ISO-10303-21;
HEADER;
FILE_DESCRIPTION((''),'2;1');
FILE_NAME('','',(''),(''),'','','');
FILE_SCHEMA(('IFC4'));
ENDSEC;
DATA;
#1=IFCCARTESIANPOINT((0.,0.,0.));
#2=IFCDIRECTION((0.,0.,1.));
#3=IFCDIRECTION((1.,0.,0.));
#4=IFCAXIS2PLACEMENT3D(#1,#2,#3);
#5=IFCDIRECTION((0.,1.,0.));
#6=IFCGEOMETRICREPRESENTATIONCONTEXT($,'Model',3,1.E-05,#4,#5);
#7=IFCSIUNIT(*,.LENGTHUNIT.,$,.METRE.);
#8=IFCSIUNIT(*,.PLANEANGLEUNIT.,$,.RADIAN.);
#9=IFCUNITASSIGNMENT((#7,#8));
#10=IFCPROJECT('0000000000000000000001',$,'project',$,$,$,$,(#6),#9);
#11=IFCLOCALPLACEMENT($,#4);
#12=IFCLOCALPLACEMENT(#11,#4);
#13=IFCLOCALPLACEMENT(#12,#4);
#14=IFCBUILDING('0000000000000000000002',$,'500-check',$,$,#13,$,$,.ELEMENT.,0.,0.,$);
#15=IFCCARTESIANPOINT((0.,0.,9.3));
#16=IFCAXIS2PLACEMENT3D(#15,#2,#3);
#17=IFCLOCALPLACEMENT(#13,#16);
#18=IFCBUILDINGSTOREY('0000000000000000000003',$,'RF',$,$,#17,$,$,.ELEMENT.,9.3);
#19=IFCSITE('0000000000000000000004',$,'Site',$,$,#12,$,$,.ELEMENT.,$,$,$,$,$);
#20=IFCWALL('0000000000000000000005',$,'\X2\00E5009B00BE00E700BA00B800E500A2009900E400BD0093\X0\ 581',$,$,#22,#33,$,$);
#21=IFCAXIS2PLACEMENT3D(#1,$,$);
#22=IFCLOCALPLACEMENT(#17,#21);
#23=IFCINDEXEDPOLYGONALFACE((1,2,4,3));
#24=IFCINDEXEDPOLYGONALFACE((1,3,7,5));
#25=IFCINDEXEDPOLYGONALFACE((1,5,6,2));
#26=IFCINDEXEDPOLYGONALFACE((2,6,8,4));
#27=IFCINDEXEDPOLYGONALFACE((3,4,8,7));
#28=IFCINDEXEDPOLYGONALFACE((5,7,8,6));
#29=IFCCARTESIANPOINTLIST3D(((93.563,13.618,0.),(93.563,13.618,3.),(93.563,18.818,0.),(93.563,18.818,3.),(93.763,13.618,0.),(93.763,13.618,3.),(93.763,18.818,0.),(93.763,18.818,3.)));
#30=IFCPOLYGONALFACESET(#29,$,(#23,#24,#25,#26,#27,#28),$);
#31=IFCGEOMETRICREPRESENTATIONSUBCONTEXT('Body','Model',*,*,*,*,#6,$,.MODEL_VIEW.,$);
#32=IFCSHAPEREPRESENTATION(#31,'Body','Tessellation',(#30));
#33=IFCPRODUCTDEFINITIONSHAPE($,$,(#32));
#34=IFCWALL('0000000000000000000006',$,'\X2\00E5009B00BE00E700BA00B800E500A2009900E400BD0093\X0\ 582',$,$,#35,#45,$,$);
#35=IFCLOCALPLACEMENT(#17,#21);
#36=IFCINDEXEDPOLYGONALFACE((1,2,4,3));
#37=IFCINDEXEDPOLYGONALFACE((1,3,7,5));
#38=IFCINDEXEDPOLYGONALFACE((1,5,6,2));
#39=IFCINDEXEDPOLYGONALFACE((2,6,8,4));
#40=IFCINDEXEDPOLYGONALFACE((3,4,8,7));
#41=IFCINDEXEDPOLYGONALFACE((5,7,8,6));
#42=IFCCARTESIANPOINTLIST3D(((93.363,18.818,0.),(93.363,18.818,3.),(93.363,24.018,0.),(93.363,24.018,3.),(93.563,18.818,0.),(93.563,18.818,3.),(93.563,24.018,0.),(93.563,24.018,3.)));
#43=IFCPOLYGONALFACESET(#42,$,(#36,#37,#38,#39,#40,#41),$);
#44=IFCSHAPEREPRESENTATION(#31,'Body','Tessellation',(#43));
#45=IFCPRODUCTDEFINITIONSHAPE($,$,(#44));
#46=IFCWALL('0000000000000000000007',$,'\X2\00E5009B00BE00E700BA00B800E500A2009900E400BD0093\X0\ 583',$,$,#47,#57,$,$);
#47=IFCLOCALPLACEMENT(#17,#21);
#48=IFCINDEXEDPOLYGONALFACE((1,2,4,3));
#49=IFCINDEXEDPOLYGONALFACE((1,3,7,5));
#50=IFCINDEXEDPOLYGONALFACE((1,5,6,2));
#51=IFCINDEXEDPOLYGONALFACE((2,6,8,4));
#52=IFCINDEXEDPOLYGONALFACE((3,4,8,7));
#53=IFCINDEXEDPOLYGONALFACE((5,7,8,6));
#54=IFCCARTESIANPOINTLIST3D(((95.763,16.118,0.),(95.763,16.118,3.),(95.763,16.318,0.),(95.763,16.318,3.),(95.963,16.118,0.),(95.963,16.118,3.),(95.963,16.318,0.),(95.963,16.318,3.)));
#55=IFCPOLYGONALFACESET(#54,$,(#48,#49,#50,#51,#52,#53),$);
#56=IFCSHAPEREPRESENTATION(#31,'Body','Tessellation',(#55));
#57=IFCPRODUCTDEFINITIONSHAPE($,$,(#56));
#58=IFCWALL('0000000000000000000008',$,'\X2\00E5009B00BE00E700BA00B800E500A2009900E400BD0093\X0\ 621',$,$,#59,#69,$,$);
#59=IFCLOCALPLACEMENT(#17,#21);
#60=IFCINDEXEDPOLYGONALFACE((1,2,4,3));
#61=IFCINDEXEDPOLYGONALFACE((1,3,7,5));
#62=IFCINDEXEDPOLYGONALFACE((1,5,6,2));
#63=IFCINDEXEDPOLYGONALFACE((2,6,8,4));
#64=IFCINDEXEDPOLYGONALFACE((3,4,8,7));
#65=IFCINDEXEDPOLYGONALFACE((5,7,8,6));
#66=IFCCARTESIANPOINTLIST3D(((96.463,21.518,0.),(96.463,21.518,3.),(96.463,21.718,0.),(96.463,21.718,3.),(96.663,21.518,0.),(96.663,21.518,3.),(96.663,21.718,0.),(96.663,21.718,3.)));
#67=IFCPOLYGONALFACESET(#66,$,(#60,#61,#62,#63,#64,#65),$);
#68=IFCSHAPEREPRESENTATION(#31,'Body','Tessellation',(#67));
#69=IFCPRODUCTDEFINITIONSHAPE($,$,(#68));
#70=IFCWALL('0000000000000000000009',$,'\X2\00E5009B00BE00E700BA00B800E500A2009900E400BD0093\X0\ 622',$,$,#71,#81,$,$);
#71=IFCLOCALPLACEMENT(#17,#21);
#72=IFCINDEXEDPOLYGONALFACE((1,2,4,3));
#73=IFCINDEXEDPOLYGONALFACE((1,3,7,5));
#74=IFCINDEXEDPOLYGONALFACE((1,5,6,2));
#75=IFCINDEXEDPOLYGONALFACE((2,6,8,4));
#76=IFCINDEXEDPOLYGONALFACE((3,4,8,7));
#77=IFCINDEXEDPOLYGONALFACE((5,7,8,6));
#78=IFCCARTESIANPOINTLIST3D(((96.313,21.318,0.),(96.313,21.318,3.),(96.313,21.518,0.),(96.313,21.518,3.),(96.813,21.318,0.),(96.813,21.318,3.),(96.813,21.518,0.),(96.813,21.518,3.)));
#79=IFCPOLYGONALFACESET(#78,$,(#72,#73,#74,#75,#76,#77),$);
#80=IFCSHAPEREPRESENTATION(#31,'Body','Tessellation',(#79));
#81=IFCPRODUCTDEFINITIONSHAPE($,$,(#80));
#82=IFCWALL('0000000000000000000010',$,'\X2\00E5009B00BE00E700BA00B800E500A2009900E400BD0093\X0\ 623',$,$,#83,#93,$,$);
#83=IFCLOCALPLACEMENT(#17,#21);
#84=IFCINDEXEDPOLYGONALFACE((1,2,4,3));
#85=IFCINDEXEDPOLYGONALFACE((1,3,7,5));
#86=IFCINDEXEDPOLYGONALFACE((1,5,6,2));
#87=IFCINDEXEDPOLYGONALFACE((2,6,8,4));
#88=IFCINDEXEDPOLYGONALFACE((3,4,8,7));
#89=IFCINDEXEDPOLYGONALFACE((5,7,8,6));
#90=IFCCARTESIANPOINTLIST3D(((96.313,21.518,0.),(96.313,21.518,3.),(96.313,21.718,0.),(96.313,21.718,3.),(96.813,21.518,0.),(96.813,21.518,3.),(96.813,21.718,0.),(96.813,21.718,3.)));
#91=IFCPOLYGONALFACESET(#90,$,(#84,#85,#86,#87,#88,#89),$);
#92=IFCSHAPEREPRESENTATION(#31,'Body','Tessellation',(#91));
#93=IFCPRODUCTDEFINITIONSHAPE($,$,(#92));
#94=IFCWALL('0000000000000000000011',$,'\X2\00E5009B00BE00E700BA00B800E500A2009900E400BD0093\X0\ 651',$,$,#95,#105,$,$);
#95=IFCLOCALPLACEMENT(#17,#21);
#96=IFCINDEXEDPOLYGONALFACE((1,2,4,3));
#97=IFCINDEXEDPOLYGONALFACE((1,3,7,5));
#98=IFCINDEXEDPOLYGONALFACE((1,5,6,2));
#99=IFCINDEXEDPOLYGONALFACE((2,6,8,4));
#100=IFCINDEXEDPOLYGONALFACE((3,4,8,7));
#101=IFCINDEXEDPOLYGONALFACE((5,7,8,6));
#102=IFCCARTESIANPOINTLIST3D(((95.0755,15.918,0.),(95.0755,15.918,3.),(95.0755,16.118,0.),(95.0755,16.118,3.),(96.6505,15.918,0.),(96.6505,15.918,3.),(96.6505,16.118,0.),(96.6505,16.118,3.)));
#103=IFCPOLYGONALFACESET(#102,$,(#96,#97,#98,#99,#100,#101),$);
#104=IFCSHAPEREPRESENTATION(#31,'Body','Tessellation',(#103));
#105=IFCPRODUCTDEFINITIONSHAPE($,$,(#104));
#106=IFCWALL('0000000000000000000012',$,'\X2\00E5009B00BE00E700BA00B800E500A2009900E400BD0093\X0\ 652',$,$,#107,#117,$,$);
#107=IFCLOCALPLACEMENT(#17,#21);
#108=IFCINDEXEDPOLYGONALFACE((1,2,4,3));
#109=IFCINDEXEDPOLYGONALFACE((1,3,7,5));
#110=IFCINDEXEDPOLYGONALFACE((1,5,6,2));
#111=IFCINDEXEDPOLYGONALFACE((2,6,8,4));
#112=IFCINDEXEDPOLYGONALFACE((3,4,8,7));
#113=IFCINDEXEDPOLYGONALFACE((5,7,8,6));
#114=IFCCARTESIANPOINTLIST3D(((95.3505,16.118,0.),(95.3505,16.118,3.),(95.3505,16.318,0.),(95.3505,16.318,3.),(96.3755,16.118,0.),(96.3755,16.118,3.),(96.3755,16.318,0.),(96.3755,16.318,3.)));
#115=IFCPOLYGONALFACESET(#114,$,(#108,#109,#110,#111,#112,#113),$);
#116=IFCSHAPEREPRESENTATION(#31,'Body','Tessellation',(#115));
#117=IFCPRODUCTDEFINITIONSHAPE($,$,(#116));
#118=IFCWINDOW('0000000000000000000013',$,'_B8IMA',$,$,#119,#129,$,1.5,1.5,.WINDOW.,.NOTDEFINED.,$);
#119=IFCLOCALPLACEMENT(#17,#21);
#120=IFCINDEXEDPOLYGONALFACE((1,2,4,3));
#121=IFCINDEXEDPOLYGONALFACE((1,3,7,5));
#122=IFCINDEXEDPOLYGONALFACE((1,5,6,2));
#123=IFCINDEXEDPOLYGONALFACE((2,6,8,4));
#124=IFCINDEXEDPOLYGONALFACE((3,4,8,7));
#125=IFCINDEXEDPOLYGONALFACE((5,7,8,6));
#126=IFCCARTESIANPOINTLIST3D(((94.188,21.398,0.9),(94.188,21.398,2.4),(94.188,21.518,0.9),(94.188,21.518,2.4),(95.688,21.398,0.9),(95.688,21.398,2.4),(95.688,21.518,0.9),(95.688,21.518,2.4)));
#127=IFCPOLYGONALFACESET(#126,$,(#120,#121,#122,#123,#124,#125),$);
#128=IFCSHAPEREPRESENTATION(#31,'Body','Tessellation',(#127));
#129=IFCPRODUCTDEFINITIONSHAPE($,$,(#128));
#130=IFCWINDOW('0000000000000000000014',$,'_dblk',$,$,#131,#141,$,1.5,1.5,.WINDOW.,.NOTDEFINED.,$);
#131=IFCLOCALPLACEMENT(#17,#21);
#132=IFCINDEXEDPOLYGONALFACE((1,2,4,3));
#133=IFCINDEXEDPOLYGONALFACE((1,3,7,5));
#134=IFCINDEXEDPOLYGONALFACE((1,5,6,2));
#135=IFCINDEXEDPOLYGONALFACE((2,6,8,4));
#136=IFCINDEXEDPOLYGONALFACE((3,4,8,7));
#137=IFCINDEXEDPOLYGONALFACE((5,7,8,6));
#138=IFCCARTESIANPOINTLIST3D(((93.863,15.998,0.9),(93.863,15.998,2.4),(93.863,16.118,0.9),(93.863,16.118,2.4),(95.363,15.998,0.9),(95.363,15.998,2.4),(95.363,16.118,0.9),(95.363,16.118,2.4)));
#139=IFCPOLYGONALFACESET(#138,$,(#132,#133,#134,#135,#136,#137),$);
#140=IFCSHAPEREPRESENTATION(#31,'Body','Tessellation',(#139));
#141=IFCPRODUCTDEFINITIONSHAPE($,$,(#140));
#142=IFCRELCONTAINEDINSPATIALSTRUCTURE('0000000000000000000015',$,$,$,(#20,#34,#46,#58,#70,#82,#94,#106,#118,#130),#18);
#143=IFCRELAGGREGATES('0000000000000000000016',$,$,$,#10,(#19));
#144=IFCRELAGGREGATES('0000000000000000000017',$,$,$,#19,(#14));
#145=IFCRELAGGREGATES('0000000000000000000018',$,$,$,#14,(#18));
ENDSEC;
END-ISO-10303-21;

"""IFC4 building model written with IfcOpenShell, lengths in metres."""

from ifc_helpers import new_model, si_unit, direction, frame, frame_2d, origin_with_axes, place, context, subcontext, project, spatial, rectangle, extrude, element, save


model = new_model("IFC4")

# Units and contexts
model_context = context("Model", 3, precision=1e-05, world=origin_with_axes(), true_north=direction((0.0, 1.0, 0.0)))
body_context = subcontext(model_context, "Body", "Model", "MODEL_VIEW")
ifc_project = project(units=[si_unit("LENGTHUNIT", "METRE"), si_unit("PLANEANGLEUNIT", "RADIAN")], contexts=[model_context])

# Site, building, storey
placement = place(None, origin_with_axes())
site_placement = place(placement, origin_with_axes())
site = spatial("IfcSite", under=ifc_project, at=site_placement, Name="Site", CompositionType="ELEMENT")
building_placement = place(site_placement, origin_with_axes())
building = spatial("IfcBuilding", under=site, at=building_placement, Name="500-check", CompositionType="ELEMENT", ElevationOfRefHeight=0.0, ElevationOfTerrain=0.0)
storey_placement = place(building_placement, frame((0.0, 0.0, 9.3), z_axis=(0.0, 0.0, 1.0), x_axis=(1.0, 0.0, 0.0)))
storey = spatial("IfcBuildingStorey", under=building, at=storey_placement, Name="RF", CompositionType="ELEMENT", Elevation=9.3)

# Walls
for number, where, z_axis, x_axis, name in (
    (1, (93.663, 16.218, 0.0), (0.0, 0.0, 1.0), (0.0, 1.0, 0.0), "å\u009b¾çº¸å¢\u0099ä½\u0093 581"),
    (2, (93.463, 21.418, 0.0), (0.0, 0.0, 1.0), (0.0, -1.0, 0.0), "å\u009b¾çº¸å¢\u0099ä½\u0093 582"),
):
    element("IfcWall", number, at=place(storey_placement, frame(where, z_axis=z_axis, x_axis=x_axis)), inside=storey, Name=name, context=body_context, shape_type="SweptSolid", body=[
        extrude(rectangle(XDim=5.2, YDim=0.2, at=frame_2d((0.0, 0.0), x_axis=(1.0, 0.0, 0.0))), frame((0.0, 0.0, 0.0), z_axis=(0.0, 0.0, 1.0)), (0.0, 0.0, 1.0), 3.0),
    ])
for number, where, z_axis, x_axis, name in (
    (3, (95.863, 16.218, 0.0), (0.0, 0.0, 1.0), (0.0, -1.0, 0.0), "å\u009b¾çº¸å¢\u0099ä½\u0093 583"),
    (4, (96.563, 21.618, 0.0), (0.0, 0.0, 1.0), (0.0, -1.0, 0.0), "å\u009b¾çº¸å¢\u0099ä½\u0093 621"),
):
    element("IfcWall", number, at=place(storey_placement, frame(where, z_axis=z_axis, x_axis=x_axis)), inside=storey, Name=name, context=body_context, shape_type="SweptSolid", body=[
        extrude(rectangle(XDim=0.2, YDim=0.2, at=frame_2d((0.0, 0.0), x_axis=(1.0, 0.0, 0.0))), frame((0.0, 0.0, 0.0), z_axis=(0.0, 0.0, 1.0)), (0.0, 0.0, 1.0), 3.0),
    ])
for number, where, z_axis, x_axis, name in (
    (5, (96.563, 21.418, 0.0), (0.0, 0.0, 1.0), (1.0, 0.0, 0.0), "å\u009b¾çº¸å¢\u0099ä½\u0093 622"),
    (6, (96.563, 21.618, 0.0), (0.0, 0.0, 1.0), (1.0, 0.0, 0.0), "å\u009b¾çº¸å¢\u0099ä½\u0093 623"),
):
    element("IfcWall", number, at=place(storey_placement, frame(where, z_axis=z_axis, x_axis=x_axis)), inside=storey, Name=name, context=body_context, shape_type="SweptSolid", body=[
        extrude(rectangle(XDim=0.5, YDim=0.2, at=frame_2d((0.0, 0.0), x_axis=(1.0, 0.0, 0.0))), frame((0.0, 0.0, 0.0), z_axis=(0.0, 0.0, 1.0)), (0.0, 0.0, 1.0), 3.0),
    ])
wall_1_placement = place(storey_placement, frame((95.863, 16.018, 0.0), z_axis=(0.0, 0.0, 1.0), x_axis=(1.0, 0.0, 0.0)))
element("IfcWall", 7, at=wall_1_placement, inside=storey, Name="å\u009b¾çº¸å¢\u0099ä½\u0093 651", context=body_context, shape_type="SweptSolid", body=[
    extrude(rectangle(XDim=1.575, YDim=0.2, at=frame_2d((0.0, 0.0), x_axis=(1.0, 0.0, 0.0))), frame((0.0, 0.0, 0.0), z_axis=(0.0, 0.0, 1.0)), (0.0, 0.0, 1.0), 3.0),
])
wall_2_placement = place(storey_placement, frame((95.863, 16.218, 0.0), z_axis=(0.0, 0.0, 1.0), x_axis=(1.0, 0.0, 0.0)))
element("IfcWall", 8, at=wall_2_placement, inside=storey, Name="å\u009b¾çº¸å¢\u0099ä½\u0093 652", context=body_context, shape_type="SweptSolid", body=[
    extrude(rectangle(XDim=1.025, YDim=0.2, at=frame_2d((0.0, 0.0), x_axis=(1.0, 0.0, 0.0))), frame((0.0, 0.0, 0.0), z_axis=(0.0, 0.0, 1.0)), (0.0, 0.0, 1.0), 3.0),
])

# Windows
for number, where, z_axis, x_axis, name in (
    (9, (94.938, 21.458, 0.9), (0.0, 0.0, 1.0), (1.0, 0.0, 0.0), "_B8IMA"),
    (10, (94.613, 16.058, 0.9), (0.0, 0.0, 1.0), (1.0, 0.0, 0.0), "_dblk"),
):
    element("IfcWindow", number, at=place(storey_placement, frame(where, z_axis=z_axis, x_axis=x_axis)), inside=storey, Name=name, OverallHeight=1.5, OverallWidth=1.5, PartitioningType="NOTDEFINED", PredefinedType="WINDOW", context=body_context, shape_type="SweptSolid", body=[
        extrude(rectangle(XDim=1.5, YDim=0.12, at=frame_2d((0.0, 0.0), x_axis=(1.0, 0.0, 0.0))), frame((0.0, 0.0, 0.0), z_axis=(0.0, 0.0, 1.0)), (0.0, 0.0, 1.0), 1.5),
    ])

save(model, "model.ifc")
